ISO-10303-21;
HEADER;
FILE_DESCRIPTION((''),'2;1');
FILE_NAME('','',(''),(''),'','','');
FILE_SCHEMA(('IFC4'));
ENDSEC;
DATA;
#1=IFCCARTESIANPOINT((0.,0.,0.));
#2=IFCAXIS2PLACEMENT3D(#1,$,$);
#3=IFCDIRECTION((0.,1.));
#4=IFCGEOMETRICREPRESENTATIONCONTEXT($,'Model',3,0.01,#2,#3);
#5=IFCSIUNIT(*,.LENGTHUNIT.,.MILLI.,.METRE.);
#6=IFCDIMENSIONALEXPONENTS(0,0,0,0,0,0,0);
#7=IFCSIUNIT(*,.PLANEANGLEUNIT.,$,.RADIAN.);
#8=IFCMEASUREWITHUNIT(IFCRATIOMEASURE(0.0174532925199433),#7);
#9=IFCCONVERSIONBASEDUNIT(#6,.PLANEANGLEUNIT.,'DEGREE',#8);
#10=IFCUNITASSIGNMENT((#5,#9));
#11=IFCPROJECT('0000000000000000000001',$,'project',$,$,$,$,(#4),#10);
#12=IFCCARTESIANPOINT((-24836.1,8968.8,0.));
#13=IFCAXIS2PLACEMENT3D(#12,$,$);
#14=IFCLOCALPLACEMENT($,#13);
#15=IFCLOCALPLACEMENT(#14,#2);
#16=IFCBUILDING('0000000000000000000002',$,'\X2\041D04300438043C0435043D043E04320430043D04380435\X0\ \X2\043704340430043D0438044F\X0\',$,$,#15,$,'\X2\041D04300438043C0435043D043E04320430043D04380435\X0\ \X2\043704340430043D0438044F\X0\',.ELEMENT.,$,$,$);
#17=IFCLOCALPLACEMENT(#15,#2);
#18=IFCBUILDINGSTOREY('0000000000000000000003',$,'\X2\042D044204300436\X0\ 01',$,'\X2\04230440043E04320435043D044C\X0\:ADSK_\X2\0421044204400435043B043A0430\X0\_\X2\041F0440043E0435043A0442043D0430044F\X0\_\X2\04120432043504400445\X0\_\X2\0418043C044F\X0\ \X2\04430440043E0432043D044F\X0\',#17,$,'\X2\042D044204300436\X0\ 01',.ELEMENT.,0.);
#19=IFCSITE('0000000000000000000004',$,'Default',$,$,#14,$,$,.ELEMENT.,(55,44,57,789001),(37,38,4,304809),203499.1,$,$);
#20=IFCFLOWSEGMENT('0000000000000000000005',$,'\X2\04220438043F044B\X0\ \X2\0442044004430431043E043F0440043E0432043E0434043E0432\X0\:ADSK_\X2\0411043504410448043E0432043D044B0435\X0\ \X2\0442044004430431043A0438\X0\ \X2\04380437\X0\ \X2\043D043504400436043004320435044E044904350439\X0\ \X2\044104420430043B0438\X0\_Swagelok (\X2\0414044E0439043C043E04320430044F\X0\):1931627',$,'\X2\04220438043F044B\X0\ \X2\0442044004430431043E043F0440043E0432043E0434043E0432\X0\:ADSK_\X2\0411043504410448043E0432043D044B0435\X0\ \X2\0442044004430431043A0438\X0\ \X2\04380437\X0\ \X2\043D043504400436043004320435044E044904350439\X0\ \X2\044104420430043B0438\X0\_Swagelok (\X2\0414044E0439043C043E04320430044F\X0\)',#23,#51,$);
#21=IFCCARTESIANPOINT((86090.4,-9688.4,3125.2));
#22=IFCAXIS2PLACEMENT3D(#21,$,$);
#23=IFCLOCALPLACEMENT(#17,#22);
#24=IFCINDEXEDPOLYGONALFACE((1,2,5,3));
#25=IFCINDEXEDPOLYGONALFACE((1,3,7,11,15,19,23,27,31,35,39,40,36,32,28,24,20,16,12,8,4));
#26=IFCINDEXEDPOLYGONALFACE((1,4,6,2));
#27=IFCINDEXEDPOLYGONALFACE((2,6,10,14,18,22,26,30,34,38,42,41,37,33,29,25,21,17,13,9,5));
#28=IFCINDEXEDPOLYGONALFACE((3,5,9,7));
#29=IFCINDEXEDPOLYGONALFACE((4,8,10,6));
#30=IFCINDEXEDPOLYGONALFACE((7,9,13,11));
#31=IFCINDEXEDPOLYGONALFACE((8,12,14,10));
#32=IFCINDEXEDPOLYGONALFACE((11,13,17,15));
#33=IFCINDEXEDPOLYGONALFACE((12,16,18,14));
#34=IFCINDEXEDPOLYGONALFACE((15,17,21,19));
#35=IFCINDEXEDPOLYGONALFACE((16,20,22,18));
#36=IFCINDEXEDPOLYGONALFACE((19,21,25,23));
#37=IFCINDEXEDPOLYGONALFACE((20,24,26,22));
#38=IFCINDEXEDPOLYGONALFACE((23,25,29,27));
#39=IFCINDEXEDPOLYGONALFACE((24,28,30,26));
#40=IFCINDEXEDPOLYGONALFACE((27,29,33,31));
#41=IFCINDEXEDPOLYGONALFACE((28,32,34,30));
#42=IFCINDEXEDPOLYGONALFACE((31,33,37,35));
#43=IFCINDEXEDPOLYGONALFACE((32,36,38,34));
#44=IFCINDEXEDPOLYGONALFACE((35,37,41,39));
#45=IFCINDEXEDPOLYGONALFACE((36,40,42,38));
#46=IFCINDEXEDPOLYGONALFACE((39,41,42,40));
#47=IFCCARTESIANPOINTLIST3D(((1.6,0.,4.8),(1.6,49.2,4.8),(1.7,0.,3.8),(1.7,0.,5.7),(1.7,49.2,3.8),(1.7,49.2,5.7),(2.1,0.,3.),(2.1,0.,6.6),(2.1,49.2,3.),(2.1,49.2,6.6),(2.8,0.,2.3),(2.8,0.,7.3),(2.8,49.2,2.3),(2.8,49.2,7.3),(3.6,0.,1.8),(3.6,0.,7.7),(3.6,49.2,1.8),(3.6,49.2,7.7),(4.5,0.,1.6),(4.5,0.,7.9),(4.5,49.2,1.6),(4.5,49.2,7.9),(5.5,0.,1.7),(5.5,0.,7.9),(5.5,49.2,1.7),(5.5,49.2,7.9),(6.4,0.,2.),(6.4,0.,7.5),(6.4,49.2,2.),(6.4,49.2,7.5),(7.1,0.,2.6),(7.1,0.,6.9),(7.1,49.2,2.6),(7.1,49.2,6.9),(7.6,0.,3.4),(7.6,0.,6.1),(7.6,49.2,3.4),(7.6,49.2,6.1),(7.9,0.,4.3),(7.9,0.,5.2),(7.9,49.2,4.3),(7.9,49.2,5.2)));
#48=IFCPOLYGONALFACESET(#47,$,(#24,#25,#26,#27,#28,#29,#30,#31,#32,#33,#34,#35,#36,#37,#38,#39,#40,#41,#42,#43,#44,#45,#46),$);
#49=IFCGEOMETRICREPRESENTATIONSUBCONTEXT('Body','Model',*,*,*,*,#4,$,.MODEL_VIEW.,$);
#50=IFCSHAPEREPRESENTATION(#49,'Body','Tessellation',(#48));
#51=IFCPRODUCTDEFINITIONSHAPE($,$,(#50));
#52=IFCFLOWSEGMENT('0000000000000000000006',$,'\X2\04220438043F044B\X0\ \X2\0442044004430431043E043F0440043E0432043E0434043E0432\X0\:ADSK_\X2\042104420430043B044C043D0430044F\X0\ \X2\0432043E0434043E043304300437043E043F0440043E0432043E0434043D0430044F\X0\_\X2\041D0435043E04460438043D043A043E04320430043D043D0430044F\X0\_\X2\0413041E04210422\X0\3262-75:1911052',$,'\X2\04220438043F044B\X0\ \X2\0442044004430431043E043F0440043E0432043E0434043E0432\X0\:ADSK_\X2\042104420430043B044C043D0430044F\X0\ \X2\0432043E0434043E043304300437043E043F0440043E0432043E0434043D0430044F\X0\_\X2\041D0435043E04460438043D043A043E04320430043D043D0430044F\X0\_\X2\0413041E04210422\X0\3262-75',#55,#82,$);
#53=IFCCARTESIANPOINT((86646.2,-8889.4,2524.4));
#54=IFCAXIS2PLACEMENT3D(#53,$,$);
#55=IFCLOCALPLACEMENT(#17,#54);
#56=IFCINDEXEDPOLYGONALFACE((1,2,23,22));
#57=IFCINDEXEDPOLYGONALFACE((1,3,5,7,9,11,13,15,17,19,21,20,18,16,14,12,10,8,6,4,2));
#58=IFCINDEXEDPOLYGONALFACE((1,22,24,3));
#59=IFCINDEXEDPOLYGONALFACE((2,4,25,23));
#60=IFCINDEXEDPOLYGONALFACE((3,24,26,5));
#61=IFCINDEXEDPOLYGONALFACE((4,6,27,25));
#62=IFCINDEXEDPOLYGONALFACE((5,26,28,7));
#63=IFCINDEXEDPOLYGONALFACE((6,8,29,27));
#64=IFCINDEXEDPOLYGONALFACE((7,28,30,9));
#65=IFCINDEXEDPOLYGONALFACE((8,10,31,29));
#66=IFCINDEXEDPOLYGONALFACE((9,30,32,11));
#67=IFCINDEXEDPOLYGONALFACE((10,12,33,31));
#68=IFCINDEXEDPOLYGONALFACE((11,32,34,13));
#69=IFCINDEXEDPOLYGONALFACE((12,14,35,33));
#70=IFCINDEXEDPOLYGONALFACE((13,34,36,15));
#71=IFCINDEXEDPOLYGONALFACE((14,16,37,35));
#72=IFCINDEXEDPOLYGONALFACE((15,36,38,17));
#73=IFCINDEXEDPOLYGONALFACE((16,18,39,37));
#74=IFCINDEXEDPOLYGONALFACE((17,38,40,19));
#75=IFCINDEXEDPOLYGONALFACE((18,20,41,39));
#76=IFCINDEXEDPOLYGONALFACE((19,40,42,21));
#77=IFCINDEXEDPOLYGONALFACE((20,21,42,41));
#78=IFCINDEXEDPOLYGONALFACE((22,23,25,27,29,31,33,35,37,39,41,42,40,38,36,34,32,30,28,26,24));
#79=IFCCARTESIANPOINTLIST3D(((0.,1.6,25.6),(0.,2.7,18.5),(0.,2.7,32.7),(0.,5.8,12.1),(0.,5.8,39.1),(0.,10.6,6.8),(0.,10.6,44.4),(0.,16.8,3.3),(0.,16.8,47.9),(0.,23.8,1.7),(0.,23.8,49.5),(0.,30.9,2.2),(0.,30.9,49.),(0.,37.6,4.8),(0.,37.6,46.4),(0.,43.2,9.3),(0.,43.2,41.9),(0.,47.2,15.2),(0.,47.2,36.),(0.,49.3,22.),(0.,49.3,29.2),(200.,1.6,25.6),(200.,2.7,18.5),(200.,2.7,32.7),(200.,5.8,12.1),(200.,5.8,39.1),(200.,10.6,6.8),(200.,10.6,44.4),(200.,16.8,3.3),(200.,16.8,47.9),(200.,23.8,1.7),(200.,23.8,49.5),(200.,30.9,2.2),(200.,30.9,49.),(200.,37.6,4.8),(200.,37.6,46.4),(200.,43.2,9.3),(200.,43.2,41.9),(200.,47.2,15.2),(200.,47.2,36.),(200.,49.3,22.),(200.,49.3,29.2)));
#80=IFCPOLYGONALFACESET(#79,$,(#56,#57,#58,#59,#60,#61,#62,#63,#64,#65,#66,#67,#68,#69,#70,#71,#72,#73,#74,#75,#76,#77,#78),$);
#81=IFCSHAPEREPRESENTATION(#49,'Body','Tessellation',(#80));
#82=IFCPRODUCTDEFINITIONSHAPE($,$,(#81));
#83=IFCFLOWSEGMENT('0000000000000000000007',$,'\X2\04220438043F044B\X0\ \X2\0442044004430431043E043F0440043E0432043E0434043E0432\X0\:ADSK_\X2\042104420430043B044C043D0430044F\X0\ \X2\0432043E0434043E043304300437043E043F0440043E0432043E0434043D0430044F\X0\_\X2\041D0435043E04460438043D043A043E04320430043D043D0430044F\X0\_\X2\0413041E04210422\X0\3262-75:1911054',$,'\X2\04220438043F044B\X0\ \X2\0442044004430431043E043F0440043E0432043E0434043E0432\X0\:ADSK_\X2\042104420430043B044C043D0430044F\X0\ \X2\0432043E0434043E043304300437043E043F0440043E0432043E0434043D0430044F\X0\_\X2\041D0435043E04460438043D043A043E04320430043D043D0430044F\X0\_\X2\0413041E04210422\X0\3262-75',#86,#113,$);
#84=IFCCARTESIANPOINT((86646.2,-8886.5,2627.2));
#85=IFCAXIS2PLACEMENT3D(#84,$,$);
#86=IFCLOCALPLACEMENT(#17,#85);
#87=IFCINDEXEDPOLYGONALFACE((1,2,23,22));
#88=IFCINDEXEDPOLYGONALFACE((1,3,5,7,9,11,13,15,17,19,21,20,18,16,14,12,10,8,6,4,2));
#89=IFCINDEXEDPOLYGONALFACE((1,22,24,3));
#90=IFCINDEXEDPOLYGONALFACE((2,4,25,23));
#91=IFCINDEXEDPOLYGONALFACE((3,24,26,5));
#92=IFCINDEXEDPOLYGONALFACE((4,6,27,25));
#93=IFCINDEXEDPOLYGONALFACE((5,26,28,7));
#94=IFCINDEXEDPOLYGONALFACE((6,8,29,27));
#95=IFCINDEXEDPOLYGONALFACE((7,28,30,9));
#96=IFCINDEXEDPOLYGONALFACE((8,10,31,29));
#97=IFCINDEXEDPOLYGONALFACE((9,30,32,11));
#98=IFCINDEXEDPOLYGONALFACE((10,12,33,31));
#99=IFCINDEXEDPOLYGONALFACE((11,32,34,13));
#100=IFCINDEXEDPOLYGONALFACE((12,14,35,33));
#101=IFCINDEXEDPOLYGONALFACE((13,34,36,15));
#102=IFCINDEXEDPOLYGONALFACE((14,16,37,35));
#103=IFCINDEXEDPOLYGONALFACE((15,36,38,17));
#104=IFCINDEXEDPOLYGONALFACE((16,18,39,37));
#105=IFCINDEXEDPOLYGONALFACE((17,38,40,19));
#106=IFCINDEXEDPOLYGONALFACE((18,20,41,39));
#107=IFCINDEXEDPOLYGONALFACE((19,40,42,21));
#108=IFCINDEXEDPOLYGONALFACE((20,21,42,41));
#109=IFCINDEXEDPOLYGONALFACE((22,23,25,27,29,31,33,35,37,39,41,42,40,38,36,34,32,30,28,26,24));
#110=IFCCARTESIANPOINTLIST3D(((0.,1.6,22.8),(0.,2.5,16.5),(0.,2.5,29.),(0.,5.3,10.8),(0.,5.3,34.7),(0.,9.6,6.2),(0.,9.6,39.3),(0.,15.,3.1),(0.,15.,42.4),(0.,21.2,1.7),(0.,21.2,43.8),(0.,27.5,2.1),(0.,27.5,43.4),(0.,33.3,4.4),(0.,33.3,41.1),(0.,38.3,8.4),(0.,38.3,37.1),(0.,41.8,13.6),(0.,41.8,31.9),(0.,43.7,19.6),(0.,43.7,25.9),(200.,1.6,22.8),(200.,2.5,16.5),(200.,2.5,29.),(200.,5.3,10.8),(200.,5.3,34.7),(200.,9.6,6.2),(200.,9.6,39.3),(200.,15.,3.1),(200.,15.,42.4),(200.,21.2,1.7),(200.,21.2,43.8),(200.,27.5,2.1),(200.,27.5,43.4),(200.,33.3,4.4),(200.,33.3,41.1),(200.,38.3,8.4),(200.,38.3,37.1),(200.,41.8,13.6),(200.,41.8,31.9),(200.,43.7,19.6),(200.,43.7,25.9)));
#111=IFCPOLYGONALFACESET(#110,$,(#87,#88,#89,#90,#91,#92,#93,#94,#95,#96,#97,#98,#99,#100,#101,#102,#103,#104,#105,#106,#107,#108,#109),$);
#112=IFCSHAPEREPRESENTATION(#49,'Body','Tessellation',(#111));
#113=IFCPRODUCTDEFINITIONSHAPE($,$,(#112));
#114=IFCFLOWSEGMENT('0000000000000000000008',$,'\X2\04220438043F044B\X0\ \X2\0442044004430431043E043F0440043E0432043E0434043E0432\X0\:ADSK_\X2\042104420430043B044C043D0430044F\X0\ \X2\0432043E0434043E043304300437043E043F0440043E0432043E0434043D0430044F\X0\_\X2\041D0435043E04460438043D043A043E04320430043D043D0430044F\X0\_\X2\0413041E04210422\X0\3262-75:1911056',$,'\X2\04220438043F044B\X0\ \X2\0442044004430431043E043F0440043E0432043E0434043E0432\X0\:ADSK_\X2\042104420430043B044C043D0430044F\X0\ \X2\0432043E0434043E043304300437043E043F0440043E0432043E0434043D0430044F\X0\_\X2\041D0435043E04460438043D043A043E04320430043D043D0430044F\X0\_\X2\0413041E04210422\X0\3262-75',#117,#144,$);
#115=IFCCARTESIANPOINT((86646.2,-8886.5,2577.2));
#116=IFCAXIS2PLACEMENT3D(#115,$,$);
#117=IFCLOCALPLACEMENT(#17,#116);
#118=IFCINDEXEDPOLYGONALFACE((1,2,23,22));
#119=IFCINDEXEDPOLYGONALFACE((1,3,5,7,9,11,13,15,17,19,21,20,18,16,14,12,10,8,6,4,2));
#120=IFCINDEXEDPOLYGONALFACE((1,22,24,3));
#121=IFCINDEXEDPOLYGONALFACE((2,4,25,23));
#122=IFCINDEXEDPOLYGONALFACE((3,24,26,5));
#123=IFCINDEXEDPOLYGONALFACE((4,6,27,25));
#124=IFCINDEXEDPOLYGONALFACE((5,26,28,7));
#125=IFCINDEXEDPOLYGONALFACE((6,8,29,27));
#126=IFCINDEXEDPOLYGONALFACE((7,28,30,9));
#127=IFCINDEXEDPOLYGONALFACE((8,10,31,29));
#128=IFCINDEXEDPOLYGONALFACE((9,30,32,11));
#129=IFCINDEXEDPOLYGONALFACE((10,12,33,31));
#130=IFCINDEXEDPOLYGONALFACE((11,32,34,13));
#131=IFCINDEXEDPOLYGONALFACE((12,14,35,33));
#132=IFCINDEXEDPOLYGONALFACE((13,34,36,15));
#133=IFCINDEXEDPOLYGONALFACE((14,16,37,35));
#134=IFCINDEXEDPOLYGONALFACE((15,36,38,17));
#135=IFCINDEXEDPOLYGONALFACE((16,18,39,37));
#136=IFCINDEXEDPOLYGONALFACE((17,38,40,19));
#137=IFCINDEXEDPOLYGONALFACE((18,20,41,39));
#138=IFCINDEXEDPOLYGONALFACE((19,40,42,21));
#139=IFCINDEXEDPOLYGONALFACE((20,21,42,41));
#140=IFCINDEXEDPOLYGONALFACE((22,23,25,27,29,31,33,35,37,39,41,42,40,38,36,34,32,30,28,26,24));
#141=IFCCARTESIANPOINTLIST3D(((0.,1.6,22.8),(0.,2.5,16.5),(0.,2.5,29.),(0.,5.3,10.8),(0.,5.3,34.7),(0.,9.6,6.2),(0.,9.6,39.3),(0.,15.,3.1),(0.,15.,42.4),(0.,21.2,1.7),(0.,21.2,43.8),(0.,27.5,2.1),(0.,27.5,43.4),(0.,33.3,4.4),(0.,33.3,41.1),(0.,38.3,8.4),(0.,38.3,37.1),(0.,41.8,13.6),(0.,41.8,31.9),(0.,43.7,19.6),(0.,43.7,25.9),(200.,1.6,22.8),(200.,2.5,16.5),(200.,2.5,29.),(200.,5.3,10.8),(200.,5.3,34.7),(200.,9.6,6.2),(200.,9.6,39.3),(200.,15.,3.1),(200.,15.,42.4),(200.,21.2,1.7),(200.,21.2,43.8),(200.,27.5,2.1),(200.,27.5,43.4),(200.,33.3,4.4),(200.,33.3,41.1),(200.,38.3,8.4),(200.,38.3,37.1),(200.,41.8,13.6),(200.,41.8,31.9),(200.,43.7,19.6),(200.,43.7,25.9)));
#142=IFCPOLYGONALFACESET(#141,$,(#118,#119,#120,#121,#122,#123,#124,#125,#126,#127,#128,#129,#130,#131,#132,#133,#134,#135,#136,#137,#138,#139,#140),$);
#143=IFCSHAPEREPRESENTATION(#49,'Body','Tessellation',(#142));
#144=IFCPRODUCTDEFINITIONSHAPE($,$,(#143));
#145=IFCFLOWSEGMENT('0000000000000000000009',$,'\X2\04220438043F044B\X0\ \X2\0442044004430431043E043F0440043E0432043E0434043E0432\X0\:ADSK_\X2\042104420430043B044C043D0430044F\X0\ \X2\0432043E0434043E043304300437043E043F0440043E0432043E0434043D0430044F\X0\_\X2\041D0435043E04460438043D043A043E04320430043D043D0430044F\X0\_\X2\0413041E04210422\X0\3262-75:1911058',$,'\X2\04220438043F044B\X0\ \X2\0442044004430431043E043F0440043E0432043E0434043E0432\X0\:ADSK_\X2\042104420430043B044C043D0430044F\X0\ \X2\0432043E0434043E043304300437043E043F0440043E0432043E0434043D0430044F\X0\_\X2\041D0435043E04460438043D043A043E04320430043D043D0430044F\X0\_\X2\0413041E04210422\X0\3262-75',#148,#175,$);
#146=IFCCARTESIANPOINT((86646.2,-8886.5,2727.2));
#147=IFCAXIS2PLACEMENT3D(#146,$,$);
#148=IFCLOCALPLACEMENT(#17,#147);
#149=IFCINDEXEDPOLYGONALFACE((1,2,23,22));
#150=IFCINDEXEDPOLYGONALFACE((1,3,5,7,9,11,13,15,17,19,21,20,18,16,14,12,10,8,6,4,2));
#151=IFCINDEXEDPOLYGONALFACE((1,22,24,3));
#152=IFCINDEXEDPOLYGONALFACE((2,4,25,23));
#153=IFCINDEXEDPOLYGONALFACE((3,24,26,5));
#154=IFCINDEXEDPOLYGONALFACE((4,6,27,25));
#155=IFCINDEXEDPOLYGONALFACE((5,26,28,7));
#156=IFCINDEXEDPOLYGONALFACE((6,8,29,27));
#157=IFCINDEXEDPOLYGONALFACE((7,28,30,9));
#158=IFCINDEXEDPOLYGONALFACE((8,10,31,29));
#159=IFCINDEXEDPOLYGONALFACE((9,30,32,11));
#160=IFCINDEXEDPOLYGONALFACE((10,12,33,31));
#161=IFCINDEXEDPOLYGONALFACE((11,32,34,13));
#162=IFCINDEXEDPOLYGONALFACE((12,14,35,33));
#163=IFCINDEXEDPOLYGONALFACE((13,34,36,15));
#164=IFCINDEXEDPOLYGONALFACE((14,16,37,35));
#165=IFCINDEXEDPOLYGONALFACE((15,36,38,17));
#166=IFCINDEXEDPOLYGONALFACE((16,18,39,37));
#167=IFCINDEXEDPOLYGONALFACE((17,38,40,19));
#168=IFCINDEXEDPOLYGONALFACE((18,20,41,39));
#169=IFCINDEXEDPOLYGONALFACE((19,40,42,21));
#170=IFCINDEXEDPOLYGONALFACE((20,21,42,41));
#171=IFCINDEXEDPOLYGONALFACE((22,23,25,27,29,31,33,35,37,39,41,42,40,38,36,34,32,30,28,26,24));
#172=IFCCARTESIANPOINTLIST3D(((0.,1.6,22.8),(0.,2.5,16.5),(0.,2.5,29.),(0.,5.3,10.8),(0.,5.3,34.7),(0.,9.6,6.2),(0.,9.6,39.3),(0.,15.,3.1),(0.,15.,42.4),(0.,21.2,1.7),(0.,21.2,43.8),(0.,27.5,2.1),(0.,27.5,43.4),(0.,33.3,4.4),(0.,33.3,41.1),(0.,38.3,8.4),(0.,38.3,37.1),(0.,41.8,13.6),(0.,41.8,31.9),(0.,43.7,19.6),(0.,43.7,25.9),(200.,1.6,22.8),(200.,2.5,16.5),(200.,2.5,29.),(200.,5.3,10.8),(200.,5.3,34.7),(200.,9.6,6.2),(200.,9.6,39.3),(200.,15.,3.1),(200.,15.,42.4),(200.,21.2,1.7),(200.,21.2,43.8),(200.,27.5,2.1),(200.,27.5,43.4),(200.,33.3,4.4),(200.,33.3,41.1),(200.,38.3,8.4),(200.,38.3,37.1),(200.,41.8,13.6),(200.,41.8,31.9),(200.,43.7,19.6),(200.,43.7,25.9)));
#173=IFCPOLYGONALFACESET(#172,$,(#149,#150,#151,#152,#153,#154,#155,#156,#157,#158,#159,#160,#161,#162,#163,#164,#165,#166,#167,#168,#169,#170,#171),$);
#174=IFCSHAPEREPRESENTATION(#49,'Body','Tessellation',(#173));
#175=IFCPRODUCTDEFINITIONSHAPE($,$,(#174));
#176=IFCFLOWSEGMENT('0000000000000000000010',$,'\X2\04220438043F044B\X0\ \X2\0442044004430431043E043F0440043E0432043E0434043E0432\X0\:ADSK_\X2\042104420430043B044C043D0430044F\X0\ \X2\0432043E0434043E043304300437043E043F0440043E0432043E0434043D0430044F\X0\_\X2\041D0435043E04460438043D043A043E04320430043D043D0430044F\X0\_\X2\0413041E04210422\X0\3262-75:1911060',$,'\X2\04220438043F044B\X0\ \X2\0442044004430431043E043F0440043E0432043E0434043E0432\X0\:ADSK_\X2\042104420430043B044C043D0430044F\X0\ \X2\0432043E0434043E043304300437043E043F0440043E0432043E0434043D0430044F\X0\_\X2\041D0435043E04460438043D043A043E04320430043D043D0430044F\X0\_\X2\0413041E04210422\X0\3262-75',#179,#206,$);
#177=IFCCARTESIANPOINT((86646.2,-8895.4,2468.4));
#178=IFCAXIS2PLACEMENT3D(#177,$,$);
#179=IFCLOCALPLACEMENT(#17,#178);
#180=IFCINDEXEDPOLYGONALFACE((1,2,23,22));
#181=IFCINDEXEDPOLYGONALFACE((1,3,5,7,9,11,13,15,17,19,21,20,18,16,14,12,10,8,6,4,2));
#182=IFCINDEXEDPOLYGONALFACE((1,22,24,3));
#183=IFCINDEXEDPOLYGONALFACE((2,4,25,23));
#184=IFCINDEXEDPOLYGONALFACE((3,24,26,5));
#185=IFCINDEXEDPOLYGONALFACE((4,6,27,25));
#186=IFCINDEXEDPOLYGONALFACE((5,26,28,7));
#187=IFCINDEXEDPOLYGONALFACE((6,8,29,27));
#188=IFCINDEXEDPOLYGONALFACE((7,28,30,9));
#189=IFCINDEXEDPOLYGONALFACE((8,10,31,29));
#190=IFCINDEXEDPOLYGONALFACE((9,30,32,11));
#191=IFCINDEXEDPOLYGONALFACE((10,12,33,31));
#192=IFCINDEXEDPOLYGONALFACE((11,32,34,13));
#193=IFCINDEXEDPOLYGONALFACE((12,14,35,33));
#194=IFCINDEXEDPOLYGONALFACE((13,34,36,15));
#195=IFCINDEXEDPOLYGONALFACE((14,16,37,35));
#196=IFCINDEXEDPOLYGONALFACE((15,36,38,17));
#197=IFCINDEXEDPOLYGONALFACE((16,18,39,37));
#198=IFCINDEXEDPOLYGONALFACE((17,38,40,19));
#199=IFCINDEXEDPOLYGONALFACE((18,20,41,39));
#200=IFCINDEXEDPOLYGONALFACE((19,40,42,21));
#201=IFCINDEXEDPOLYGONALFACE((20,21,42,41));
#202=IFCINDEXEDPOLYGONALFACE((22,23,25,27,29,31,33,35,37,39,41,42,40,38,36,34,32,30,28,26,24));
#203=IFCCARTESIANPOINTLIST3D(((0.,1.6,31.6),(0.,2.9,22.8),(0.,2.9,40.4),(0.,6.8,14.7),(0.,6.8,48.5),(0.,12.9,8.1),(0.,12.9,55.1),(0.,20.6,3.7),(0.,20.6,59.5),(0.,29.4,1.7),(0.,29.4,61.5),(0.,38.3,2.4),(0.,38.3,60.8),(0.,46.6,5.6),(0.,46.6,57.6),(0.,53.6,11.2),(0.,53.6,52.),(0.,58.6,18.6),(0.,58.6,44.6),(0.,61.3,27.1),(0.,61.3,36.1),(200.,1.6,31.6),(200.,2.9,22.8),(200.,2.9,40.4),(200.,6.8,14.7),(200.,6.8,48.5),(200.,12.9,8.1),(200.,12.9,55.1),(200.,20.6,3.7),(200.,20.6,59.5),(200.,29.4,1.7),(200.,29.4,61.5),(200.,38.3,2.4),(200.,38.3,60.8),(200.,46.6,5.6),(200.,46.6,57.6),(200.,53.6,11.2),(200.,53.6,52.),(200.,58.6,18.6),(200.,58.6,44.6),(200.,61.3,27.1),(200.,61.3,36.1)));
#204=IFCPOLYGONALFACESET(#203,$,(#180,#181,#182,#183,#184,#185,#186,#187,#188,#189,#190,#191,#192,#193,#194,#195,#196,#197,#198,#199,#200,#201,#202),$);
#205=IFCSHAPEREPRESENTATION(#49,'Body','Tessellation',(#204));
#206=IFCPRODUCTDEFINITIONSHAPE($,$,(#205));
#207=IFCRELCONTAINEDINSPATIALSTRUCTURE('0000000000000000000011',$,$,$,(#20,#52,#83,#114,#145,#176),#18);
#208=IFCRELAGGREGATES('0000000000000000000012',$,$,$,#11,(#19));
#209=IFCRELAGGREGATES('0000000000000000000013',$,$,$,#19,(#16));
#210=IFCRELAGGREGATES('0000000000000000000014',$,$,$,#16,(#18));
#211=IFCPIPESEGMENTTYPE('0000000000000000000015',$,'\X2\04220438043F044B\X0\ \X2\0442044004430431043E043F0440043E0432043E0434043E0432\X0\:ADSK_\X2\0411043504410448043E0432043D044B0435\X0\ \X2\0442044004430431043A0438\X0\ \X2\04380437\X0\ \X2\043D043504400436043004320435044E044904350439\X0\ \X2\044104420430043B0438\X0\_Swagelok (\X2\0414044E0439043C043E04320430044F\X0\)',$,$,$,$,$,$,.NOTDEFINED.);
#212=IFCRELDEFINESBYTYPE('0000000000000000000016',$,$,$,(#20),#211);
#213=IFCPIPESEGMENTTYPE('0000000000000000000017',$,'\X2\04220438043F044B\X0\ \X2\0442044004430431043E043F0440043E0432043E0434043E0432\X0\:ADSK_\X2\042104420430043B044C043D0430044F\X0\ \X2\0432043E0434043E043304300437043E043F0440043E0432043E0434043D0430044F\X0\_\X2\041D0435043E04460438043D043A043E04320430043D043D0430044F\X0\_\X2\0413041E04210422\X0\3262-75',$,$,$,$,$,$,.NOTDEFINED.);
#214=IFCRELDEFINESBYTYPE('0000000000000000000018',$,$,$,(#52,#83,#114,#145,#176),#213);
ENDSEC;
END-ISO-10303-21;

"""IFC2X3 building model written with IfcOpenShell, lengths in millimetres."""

from ifc_helpers import new_model, entity, si_unit, converted_unit, direction, frame, origin, origin_2d_with_axis, place, context, subcontext, project, spatial, circle, extrude, type_object, element, save


model = new_model("IFC2X3")

# Units and contexts
model_context = context("Model", 3, precision=0.01, world=origin(), true_north=direction((0.0, 1.0)))
body_context = subcontext(model_context, "Body", "Model", "MODEL_VIEW")
ifc_project = project(units=[si_unit("LENGTHUNIT", "METRE", prefix="MILLI"), converted_unit("PLANEANGLEUNIT", "DEGREE", entity("IfcRatioMeasure", 0.0174532925199433), si_unit("PLANEANGLEUNIT", "RADIAN"), dimensions=[0, 0, 0, 0, 0, 0, 0])], contexts=[model_context])

# Site, building, storey
site_placement = place(None, frame((-24836.1, 8968.8, 0.0)))
site = spatial("IfcSite", under=ifc_project, at=site_placement, Name="Default", CompositionType="ELEMENT", RefLatitude=(55, 44, 57, 789001), RefLongitude=(37, 38, 4, 304809), RefElevation=203499.1)
building_placement = place(site_placement, origin())
building = spatial("IfcBuilding", under=site, at=building_placement, Name="Наименование здания", LongName="Наименование здания", CompositionType="ELEMENT")
storey_placement = place(building_placement, origin())
storey = spatial("IfcBuildingStorey", under=building, at=storey_placement, Name="Этаж 01", ObjectType="Уровень:ADSK_Стрелка_Проектная_Вверх_Имя уровня", LongName="Этаж 01", CompositionType="ELEMENT", Elevation=0.0)

# Flow segments
pipe_segment_type_1 = type_object("IfcPipeSegmentType", Name="Типы трубопроводов:ADSK_Бесшовные трубки из нержавеющей стали_Swagelok (Дюймовая)", PredefinedType="NOTDEFINED")
flow_segment_1_placement = place(storey_placement, frame((86090.4, -9688.4, 3125.2)))
element("IfcFlowSegment", 1, at=flow_segment_1_placement, inside=storey, type_object=pipe_segment_type_1, Name="Типы трубопроводов:ADSK_Бесшовные трубки из нержавеющей стали_Swagelok (Дюймовая):1931627", ObjectType="Типы трубопроводов:ADSK_Бесшовные трубки из нержавеющей стали_Swagelok (Дюймовая)", context=body_context, shape_type="SweptSolid", body=[
    extrude(circle(Radius=3.2, at=origin_2d_with_axis()), frame((4.8, 0.0, 4.8), z_axis=(0.0, 1.0, 0.0), x_axis=(-1.0, 0.0, 0.0)), (0.0, 0.0, 1.0), 49.2),
])
pipe_segment_type_2 = type_object("IfcPipeSegmentType", Name="Типы трубопроводов:ADSK_Стальная водогазопроводная_Неоцинкованная_ГОСТ3262-75", PredefinedType="NOTDEFINED")
flow_segment_2_placement = place(storey_placement, frame((86646.2, -8889.4, 2524.4)))
element("IfcFlowSegment", 2, at=flow_segment_2_placement, inside=storey, type_object=pipe_segment_type_2, Name="Типы трубопроводов:ADSK_Стальная водогазопроводная_Неоцинкованная_ГОСТ3262-75:1911052", ObjectType="Типы трубопроводов:ADSK_Стальная водогазопроводная_Неоцинкованная_ГОСТ3262-75", context=body_context, shape_type="SweptSolid", body=[
    extrude(circle(Radius=24.0, at=origin_2d_with_axis()), frame((0.0, 25.6, 25.6), z_axis=(1.0, 0.0, 0.0), x_axis=(0.0, -1.0, 0.0)), (0.0, 0.0, 1.0), 200.0),
])
for number, where, name in (
    (3, (86646.2, -8886.5, 2627.2), "Типы трубопроводов:ADSK_Стальная водогазопроводная_Неоцинкованная_ГОСТ3262-75:1911054"),
    (4, (86646.2, -8886.5, 2577.2), "Типы трубопроводов:ADSK_Стальная водогазопроводная_Неоцинкованная_ГОСТ3262-75:1911056"),
):
    element("IfcFlowSegment", number, at=place(storey_placement, frame(where)), inside=storey, type_object=pipe_segment_type_2, Name=name, ObjectType="Типы трубопроводов:ADSK_Стальная водогазопроводная_Неоцинкованная_ГОСТ3262-75", context=body_context, shape_type="SweptSolid", body=[
        extrude(circle(Radius=21.1, at=origin_2d_with_axis()), frame((0.0, 22.8, 22.8), z_axis=(1.0, 0.0, 0.0), x_axis=(0.0, -1.0, 0.0)), (0.0, 0.0, 1.0), 200.0),
    ])
flow_segment_3_placement = place(storey_placement, frame((86646.2, -8886.5, 2727.2)))
element("IfcFlowSegment", 5, at=flow_segment_3_placement, inside=storey, type_object=pipe_segment_type_2, Name="Типы трубопроводов:ADSK_Стальная водогазопроводная_Неоцинкованная_ГОСТ3262-75:1911058", ObjectType="Типы трубопроводов:ADSK_Стальная водогазопроводная_Неоцинкованная_ГОСТ3262-75", context=body_context, shape_type="SweptSolid", body=[
    extrude(circle(Radius=21.1, at=origin_2d_with_axis()), frame((0.0, 22.8, 22.8), z_axis=(1.0, 0.0, 0.0), x_axis=(0.0, -1.0, 0.0)), (0.0, 0.0, 1.0), 200.0),
])
flow_segment_4_placement = place(storey_placement, frame((86646.2, -8895.4, 2468.4)))
element("IfcFlowSegment", 6, at=flow_segment_4_placement, inside=storey, type_object=pipe_segment_type_2, Name="Типы трубопроводов:ADSK_Стальная водогазопроводная_Неоцинкованная_ГОСТ3262-75:1911060", ObjectType="Типы трубопроводов:ADSK_Стальная водогазопроводная_Неоцинкованная_ГОСТ3262-75", context=body_context, shape_type="SweptSolid", body=[
    extrude(circle(Radius=30.0, at=origin_2d_with_axis()), frame((0.0, 31.6, 31.6), z_axis=(1.0, 0.0, 0.0), x_axis=(0.0, -1.0, 0.0)), (0.0, 0.0, 1.0), 200.0),
])

save(model, "model.ifc")
